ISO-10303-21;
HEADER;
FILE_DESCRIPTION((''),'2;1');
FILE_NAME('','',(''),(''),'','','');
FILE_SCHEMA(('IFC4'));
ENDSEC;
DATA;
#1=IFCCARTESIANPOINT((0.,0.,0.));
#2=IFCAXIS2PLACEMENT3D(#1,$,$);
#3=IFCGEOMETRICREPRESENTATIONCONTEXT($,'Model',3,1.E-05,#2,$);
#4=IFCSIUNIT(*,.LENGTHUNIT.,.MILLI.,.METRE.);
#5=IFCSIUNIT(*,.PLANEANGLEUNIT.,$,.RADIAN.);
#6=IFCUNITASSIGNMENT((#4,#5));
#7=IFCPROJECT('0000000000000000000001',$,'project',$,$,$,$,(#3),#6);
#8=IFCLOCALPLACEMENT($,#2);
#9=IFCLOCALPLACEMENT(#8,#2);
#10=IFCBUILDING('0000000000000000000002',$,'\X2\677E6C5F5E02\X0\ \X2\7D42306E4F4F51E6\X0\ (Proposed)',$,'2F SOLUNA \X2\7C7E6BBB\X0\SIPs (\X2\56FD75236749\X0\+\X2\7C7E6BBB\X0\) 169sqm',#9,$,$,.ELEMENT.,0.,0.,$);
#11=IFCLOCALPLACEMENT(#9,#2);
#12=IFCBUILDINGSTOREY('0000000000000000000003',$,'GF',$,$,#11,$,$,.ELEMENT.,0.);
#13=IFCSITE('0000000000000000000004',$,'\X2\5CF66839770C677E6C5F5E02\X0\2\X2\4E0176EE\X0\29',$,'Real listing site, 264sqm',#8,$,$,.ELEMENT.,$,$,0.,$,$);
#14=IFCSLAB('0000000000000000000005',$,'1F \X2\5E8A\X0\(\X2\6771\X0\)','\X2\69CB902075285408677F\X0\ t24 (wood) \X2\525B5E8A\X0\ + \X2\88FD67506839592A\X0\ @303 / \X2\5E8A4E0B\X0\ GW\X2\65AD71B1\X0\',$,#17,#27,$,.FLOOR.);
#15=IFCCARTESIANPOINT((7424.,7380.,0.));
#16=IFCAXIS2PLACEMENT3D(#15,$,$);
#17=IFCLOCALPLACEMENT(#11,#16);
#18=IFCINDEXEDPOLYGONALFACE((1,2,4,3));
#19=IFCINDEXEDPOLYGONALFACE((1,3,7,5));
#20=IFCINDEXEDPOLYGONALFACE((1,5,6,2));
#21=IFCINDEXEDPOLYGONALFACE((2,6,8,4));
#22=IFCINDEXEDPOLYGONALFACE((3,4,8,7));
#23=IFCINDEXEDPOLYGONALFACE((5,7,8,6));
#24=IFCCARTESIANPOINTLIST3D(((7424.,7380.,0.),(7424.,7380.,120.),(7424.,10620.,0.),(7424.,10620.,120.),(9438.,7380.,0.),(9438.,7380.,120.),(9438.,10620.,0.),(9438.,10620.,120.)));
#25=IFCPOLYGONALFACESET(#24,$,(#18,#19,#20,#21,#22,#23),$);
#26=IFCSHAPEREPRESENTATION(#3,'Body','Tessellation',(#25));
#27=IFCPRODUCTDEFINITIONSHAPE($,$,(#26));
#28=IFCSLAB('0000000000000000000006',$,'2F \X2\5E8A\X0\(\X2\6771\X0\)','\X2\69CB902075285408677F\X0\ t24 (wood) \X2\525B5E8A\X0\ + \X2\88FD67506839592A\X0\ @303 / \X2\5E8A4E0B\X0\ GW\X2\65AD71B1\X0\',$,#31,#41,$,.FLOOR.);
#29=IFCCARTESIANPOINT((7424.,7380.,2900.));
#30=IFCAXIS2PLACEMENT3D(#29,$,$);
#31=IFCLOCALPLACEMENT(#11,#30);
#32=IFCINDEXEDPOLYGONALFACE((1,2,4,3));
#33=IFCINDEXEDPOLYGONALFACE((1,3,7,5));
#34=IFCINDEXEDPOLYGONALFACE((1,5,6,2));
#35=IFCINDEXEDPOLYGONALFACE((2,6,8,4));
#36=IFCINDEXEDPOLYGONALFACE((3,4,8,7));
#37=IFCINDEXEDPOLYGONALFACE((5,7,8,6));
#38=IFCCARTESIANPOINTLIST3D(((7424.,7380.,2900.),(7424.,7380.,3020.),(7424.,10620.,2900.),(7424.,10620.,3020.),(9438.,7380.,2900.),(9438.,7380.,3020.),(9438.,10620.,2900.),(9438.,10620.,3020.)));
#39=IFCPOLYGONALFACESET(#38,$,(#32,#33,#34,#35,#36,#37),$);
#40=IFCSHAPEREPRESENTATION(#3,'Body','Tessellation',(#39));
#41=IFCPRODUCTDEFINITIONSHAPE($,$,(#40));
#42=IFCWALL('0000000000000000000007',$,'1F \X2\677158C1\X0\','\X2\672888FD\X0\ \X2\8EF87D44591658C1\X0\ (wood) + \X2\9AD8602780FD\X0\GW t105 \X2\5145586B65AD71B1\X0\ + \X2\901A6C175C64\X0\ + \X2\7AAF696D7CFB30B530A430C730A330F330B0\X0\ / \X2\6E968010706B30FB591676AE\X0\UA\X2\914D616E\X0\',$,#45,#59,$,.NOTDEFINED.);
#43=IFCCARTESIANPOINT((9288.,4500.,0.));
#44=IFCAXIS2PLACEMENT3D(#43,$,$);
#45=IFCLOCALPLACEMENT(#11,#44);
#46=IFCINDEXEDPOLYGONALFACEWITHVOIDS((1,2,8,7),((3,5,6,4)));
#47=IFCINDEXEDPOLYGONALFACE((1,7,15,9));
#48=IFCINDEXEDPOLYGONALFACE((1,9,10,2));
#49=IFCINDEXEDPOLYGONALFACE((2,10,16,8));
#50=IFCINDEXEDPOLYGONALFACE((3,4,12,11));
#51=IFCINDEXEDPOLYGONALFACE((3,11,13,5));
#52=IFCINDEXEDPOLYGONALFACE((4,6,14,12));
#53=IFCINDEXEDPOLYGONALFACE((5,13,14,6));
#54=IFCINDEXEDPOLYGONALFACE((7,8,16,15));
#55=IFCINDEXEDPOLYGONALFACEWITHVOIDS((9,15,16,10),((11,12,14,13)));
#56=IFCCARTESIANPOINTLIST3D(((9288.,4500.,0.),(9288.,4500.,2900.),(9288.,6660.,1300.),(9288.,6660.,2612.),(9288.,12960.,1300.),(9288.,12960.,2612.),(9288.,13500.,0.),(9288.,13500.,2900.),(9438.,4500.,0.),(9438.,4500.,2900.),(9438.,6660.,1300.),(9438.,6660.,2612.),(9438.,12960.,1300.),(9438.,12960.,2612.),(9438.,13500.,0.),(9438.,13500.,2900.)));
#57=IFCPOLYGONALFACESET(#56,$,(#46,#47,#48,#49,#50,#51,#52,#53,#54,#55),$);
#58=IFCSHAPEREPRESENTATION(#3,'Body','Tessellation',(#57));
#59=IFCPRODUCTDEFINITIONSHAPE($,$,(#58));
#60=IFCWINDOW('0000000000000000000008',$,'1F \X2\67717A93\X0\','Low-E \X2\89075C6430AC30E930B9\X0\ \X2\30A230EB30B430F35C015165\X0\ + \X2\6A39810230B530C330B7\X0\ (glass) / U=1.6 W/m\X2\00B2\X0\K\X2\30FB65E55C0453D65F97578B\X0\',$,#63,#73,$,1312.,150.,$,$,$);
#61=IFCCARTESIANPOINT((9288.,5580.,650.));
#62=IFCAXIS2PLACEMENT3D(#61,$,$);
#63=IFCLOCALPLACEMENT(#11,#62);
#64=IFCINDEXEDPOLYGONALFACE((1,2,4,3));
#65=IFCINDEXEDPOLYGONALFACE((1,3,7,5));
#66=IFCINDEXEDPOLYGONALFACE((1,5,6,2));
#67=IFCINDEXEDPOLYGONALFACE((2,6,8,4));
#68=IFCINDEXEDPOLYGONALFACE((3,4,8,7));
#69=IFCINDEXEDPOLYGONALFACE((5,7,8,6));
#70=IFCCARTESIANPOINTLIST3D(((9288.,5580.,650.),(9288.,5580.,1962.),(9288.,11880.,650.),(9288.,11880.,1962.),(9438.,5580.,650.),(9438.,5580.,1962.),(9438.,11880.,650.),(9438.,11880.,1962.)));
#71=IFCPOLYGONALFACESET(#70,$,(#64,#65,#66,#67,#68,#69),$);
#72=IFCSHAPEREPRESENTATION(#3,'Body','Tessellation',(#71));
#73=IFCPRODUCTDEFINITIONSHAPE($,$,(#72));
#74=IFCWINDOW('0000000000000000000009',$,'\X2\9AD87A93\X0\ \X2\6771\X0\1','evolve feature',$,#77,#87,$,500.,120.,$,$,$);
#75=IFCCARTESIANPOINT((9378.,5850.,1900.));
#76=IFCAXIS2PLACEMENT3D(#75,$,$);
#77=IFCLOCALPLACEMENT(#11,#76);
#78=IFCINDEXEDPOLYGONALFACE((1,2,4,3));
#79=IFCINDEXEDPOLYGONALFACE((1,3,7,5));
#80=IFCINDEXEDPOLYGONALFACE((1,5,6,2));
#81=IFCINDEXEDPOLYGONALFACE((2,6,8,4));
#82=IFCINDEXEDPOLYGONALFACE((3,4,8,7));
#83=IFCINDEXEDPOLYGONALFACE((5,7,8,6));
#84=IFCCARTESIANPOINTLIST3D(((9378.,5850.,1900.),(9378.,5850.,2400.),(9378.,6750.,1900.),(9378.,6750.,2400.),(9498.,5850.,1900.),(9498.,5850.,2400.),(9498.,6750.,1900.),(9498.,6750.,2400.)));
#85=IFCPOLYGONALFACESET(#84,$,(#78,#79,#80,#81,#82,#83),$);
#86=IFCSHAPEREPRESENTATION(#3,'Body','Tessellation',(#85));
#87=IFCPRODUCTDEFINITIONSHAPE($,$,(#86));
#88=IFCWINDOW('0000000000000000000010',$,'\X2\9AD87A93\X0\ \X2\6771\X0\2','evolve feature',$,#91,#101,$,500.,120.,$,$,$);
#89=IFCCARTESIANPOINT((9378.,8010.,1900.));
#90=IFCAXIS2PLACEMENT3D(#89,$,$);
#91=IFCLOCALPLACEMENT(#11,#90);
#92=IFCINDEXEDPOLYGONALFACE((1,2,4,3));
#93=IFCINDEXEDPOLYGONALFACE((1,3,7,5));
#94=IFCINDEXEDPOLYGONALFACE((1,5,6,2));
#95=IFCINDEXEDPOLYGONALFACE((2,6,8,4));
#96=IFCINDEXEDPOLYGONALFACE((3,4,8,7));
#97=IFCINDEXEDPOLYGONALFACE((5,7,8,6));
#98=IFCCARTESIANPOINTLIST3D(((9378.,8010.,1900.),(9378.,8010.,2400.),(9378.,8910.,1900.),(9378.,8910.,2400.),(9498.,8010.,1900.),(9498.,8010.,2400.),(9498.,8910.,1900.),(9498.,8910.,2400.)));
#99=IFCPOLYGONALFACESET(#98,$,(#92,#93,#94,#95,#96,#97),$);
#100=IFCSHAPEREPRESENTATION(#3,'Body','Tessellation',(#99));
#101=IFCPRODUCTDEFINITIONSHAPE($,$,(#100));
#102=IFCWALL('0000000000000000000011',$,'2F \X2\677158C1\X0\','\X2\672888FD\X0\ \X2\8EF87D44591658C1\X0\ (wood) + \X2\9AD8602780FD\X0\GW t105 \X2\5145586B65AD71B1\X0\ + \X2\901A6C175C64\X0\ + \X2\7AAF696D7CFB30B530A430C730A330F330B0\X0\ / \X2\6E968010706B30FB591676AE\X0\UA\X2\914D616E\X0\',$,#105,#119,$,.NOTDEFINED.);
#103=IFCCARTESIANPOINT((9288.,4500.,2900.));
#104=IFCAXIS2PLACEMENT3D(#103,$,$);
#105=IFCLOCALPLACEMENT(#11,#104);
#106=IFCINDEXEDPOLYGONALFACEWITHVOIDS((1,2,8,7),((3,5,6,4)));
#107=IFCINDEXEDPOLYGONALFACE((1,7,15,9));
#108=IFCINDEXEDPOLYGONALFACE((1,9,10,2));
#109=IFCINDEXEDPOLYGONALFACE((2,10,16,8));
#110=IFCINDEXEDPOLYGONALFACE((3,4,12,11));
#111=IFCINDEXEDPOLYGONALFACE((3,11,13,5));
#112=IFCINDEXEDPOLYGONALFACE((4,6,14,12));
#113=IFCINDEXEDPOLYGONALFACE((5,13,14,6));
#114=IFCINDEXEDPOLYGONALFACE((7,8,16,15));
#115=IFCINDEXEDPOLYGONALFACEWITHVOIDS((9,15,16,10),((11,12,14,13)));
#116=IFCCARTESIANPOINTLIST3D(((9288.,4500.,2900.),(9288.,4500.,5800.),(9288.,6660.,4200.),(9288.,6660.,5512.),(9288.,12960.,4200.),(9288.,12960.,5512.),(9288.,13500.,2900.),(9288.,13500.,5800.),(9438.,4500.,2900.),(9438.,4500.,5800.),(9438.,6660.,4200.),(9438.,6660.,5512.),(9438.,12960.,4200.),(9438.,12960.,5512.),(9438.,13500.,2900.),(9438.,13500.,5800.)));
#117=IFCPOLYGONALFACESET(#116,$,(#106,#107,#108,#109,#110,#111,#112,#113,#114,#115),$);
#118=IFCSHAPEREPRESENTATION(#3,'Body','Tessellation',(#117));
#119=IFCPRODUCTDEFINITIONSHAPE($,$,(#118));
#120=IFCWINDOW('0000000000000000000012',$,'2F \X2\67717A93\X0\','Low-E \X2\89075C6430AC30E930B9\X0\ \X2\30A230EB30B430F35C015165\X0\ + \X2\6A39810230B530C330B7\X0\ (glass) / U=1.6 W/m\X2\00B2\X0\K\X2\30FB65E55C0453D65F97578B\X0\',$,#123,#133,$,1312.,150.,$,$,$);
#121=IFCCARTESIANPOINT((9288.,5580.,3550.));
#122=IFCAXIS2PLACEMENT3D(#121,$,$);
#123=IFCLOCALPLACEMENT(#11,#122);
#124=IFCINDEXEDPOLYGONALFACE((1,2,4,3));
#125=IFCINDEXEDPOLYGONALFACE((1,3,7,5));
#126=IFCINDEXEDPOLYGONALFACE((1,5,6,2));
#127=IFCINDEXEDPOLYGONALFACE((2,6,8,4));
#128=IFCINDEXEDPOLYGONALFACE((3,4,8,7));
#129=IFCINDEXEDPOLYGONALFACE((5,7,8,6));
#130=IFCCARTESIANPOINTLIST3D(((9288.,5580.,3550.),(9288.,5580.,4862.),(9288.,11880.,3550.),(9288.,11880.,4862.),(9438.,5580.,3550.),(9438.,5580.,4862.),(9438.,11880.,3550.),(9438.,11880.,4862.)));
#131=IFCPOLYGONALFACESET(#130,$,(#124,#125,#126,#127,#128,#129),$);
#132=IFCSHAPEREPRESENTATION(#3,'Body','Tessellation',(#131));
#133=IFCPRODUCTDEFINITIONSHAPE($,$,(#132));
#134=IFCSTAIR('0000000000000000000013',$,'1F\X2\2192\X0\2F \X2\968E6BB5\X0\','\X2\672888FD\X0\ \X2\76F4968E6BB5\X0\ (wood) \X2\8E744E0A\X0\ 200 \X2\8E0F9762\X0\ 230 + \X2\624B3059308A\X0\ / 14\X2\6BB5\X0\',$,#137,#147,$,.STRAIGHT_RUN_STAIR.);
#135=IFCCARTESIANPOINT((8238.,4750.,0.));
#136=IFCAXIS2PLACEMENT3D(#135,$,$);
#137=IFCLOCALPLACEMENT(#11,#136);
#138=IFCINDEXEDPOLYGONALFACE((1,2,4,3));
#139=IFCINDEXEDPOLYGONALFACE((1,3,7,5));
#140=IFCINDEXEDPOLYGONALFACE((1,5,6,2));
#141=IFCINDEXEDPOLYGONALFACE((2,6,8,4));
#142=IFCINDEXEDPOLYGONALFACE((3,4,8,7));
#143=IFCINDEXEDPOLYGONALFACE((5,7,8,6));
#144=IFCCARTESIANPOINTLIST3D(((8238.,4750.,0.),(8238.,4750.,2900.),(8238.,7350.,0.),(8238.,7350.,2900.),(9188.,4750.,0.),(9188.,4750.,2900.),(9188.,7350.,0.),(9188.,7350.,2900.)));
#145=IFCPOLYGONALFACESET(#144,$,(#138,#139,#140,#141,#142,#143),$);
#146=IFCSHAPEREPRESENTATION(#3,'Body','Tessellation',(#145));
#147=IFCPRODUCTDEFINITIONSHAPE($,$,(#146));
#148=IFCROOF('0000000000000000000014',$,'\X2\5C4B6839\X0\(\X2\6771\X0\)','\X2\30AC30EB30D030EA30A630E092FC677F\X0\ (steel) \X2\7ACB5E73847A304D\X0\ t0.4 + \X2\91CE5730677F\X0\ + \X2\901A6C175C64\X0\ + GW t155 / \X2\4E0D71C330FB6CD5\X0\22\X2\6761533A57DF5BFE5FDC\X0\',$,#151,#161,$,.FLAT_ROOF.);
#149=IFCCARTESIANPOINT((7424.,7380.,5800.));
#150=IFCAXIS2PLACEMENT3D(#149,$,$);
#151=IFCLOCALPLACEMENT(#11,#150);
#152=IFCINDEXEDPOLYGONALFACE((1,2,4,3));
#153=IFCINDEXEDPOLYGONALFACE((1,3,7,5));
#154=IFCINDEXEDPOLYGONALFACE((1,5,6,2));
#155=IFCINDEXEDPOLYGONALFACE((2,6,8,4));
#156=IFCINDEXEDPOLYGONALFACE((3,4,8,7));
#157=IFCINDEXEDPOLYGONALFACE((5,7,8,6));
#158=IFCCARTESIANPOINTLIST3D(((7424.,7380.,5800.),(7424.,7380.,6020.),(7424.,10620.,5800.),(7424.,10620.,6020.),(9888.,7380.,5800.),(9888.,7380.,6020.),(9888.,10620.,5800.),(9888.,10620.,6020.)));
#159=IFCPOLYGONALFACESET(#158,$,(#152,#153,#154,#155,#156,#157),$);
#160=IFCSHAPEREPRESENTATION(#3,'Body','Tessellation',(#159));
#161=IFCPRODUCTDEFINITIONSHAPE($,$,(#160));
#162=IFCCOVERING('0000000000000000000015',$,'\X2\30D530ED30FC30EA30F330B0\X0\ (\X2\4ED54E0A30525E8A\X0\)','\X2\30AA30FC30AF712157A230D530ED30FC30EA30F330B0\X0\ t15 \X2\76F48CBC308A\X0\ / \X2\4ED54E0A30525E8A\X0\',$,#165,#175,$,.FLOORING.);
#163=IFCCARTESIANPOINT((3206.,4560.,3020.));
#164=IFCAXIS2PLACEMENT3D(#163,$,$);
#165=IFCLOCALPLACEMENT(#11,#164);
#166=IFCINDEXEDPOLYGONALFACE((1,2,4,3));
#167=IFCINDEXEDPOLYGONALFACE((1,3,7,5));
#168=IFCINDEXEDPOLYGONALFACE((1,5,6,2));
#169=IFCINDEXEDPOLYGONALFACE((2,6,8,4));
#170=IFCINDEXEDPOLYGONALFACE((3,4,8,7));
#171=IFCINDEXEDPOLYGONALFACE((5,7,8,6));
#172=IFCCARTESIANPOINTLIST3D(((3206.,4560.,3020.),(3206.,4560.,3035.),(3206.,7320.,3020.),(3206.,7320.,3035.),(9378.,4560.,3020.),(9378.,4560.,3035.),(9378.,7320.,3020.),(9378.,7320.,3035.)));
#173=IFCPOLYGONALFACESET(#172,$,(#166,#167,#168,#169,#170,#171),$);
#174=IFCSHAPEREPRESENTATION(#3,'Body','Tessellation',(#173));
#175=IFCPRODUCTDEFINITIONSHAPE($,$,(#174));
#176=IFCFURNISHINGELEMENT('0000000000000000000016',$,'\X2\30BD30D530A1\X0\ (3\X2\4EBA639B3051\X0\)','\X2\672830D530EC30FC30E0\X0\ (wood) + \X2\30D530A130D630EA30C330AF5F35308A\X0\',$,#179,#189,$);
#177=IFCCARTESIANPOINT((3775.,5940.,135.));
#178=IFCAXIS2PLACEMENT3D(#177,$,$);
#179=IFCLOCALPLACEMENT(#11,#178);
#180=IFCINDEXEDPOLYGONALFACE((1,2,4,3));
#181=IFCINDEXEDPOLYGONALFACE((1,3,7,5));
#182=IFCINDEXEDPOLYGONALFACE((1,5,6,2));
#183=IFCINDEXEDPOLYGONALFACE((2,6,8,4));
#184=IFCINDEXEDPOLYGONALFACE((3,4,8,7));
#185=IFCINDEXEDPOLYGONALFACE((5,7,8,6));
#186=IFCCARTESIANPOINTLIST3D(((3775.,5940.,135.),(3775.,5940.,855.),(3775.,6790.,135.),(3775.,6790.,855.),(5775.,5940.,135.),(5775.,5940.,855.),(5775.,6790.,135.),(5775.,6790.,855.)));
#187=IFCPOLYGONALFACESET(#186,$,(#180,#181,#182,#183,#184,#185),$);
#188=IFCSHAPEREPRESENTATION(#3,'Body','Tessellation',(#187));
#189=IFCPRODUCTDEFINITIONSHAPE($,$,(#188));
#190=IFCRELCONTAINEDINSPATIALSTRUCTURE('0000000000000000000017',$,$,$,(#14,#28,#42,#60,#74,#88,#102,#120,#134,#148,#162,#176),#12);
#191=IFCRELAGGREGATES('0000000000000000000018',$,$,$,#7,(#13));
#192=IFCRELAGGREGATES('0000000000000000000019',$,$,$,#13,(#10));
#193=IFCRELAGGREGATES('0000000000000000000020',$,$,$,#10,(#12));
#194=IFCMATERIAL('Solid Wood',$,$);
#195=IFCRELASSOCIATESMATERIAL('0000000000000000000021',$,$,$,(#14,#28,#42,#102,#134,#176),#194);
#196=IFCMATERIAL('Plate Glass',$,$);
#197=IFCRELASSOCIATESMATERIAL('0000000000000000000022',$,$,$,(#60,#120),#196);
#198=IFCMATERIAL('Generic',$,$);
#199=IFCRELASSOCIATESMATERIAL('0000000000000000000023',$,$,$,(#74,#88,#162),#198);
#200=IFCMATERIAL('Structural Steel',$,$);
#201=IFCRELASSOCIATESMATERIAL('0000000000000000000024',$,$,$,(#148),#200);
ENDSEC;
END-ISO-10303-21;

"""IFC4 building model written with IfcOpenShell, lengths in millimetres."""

from ifc_helpers import new_model, si_unit, frame, frame_2d, origin, place, context, project, spatial, rectangle, extrude, material, element, fill, save


model = new_model("IFC4")

# Units and contexts
model_context = context("Model", 3, precision=1e-05, world=origin())
ifc_project = project(units=[si_unit("LENGTHUNIT", "METRE", prefix="MILLI"), si_unit("PLANEANGLEUNIT", "RADIAN")], contexts=[model_context])

# Site, building, storey
site_placement = place(None, origin())
site = spatial("IfcSite", under=ifc_project, at=site_placement, Name="島根県松江市2丁目29", ObjectType="Real listing site, 264sqm", CompositionType="ELEMENT", RefElevation=0.0)
building_placement = place(site_placement, origin())
building = spatial("IfcBuilding", under=site, at=building_placement, Name="松江市 終の住処 (Proposed)", ObjectType="2F SOLUNA 籾殻SIPs (国産杉+籾殻) 169sqm", CompositionType="ELEMENT", ElevationOfRefHeight=0.0, ElevationOfTerrain=0.0)
storey_placement = place(building_placement, origin())
storey = spatial("IfcBuildingStorey", under=building, at=storey_placement, Name="GF", CompositionType="ELEMENT", Elevation=0.0)

# Slabs
ifc_material_1 = material(Name="Solid Wood")
slab_1_placement = place(storey_placement, frame((7424.0, 7380.0, 0.0)))
element("IfcSlab", 1, at=slab_1_placement, inside=storey, material=ifc_material_1, Name="1F 床(東)", Description="構造用合板 t24 (wood) 剛床 + 製材根太 @303 / 床下 GW断熱", PredefinedType="FLOOR", context=model_context, shape_type="SweptSolid", body=[
    extrude(rectangle(XDim=2014.0, YDim=3240.0, at=frame_2d((1007.0, 1620.0))), frame((7424.0, 7380.0, 0.0)), (0.0, 0.0, 1.0), 120.0),
])
slab_2_placement = place(storey_placement, frame((7424.0, 7380.0, 2900.0)))
element("IfcSlab", 2, at=slab_2_placement, inside=storey, material=ifc_material_1, Name="2F 床(東)", Description="構造用合板 t24 (wood) 剛床 + 製材根太 @303 / 床下 GW断熱", PredefinedType="FLOOR", context=model_context, shape_type="SweptSolid", body=[
    extrude(rectangle(XDim=2014.0, YDim=3240.0, at=frame_2d((1007.0, 1620.0))), frame((7424.0, 7380.0, 2900.0)), (0.0, 0.0, 1.0), 120.0),
])

# Wall, openings, windows
wall_1_placement = place(storey_placement, frame((9288.0, 4500.0, 0.0)))
wall_1 = element("IfcWall", 3, at=wall_1_placement, inside=storey, material=ifc_material_1, Name="1F 東壁", Description="木製 軸組外壁 (wood) + 高性能GW t105 充填断熱 + 通気層 + 窯業系サイディング / 準耐火・外皮UA配慮", PredefinedType="NOTDEFINED", context=model_context, shape_type="SweptSolid", body=[
    extrude(rectangle(XDim=150.0, YDim=9000.0, at=frame_2d((75.0, 4500.0))), frame((9288.0, 4500.0, 0.0)), (0.0, 0.0, 1.0), 2900.0),
])
opening_1_placement = place(storey_placement, frame((9288.0, 5580.0, 650.0)))
opening_1 = element("IfcOpeningElement", 4, at=opening_1_placement, cuts=wall_1, PredefinedType="NOTDEFINED", context=model_context, shape_type="SweptSolid", body=[
    extrude(rectangle(XDim=150.0, YDim=6300.0, at=frame_2d((75.0, 3150.0))), frame((9288.0, 5580.0, 650.0)), (0.0, 0.0, 1.0), 1312.0),
])
opening_2_placement = place(storey_placement, frame((9378.0, 5850.0, 1900.0)))
opening_2 = element("IfcOpeningElement", 5, at=opening_2_placement, cuts=wall_1, PredefinedType="NOTDEFINED", context=model_context, shape_type="SweptSolid", body=[
    extrude(rectangle(XDim=120.0, YDim=900.0, at=frame_2d((60.0, 450.0))), frame((9378.0, 5850.0, 1900.0)), (0.0, 0.0, 1.0), 500.0),
])
opening_3_placement = place(storey_placement, frame((9378.0, 8010.0, 1900.0)))
opening_3 = element("IfcOpeningElement", 6, at=opening_3_placement, cuts=wall_1, PredefinedType="NOTDEFINED", context=model_context, shape_type="SweptSolid", body=[
    extrude(rectangle(XDim=120.0, YDim=900.0, at=frame_2d((60.0, 450.0))), frame((9378.0, 8010.0, 1900.0)), (0.0, 0.0, 1.0), 500.0),
])
ifc_material_2 = material(Name="Plate Glass")
window_1_placement = place(storey_placement, frame((9288.0, 5580.0, 650.0)))
window_1 = element("IfcWindow", 7, at=window_1_placement, inside=storey, material=ifc_material_2, Name="1F 東窓", Description="Low-E 複層ガラス アルゴン封入 + 樹脂サッシ (glass) / U=1.6 W/m²K・日射取得型", OverallHeight=1312.0, OverallWidth=150.0, context=model_context, shape_type="SweptSolid", body=[
    extrude(rectangle(XDim=150.0, YDim=6300.0, at=frame_2d((75.0, 3150.0))), frame((9288.0, 5580.0, 650.0)), (0.0, 0.0, 1.0), 1312.0),
])
fill(opening_1, window_1)
ifc_material_3 = material(Name="Generic")
window_2_placement = place(storey_placement, frame((9378.0, 5850.0, 1900.0)))
window_2 = element("IfcWindow", 8, at=window_2_placement, inside=storey, material=ifc_material_3, Name="高窓 東1", Description="evolve feature", OverallHeight=500.0, OverallWidth=120.0, context=model_context, shape_type="SweptSolid", body=[
    extrude(rectangle(XDim=120.0, YDim=900.0, at=frame_2d((60.0, 450.0))), frame((9378.0, 5850.0, 1900.0)), (0.0, 0.0, 1.0), 500.0),
])
fill(opening_2, window_2)
window_3_placement = place(storey_placement, frame((9378.0, 8010.0, 1900.0)))
window_3 = element("IfcWindow", 9, at=window_3_placement, inside=storey, material=ifc_material_3, Name="高窓 東2", Description="evolve feature", OverallHeight=500.0, OverallWidth=120.0, context=model_context, shape_type="SweptSolid", body=[
    extrude(rectangle(XDim=120.0, YDim=900.0, at=frame_2d((60.0, 450.0))), frame((9378.0, 8010.0, 1900.0)), (0.0, 0.0, 1.0), 500.0),
])
fill(opening_3, window_3)

# Wall, opening, window
wall_2_placement = place(storey_placement, frame((9288.0, 4500.0, 2900.0)))
wall_2 = element("IfcWall", 10, at=wall_2_placement, inside=storey, material=ifc_material_1, Name="2F 東壁", Description="木製 軸組外壁 (wood) + 高性能GW t105 充填断熱 + 通気層 + 窯業系サイディング / 準耐火・外皮UA配慮", PredefinedType="NOTDEFINED", context=model_context, shape_type="SweptSolid", body=[
    extrude(rectangle(XDim=150.0, YDim=9000.0, at=frame_2d((75.0, 4500.0))), frame((9288.0, 4500.0, 2900.0)), (0.0, 0.0, 1.0), 2900.0),
])
opening_4_placement = place(storey_placement, frame((9288.0, 5580.0, 3550.0)))
opening_4 = element("IfcOpeningElement", 11, at=opening_4_placement, cuts=wall_2, PredefinedType="NOTDEFINED", context=model_context, shape_type="SweptSolid", body=[
    extrude(rectangle(XDim=150.0, YDim=6300.0, at=frame_2d((75.0, 3150.0))), frame((9288.0, 5580.0, 3550.0)), (0.0, 0.0, 1.0), 1312.0),
])
window_4_placement = place(storey_placement, frame((9288.0, 5580.0, 3550.0)))
window_4 = element("IfcWindow", 12, at=window_4_placement, inside=storey, material=ifc_material_2, Name="2F 東窓", Description="Low-E 複層ガラス アルゴン封入 + 樹脂サッシ (glass) / U=1.6 W/m²K・日射取得型", OverallHeight=1312.0, OverallWidth=150.0, context=model_context, shape_type="SweptSolid", body=[
    extrude(rectangle(XDim=150.0, YDim=6300.0, at=frame_2d((75.0, 3150.0))), frame((9288.0, 5580.0, 3550.0)), (0.0, 0.0, 1.0), 1312.0),
])
fill(opening_4, window_4)

# Stair
stair_placement = place(storey_placement, frame((8238.0, 4750.0, 0.0)))
element("IfcStair", 13, at=stair_placement, inside=storey, material=ifc_material_1, Name="1F→2F 階段", Description="木製 直階段 (wood) 蹴上 200 踏面 230 + 手すり / 14段", PredefinedType="STRAIGHT_RUN_STAIR", context=model_context, shape_type="SweptSolid", body=[
    extrude(rectangle(XDim=950.0, YDim=2600.0, at=frame_2d((475.0, 1300.0))), frame((8238.0, 4750.0, 0.0)), (0.0, 0.0, 1.0), 2900.0),
])

# Roof
ifc_material_4 = material(Name="Structural Steel")
roof_placement = place(storey_placement, frame((7424.0, 7380.0, 5800.0)))
element("IfcRoof", 14, at=roof_placement, inside=storey, material=ifc_material_4, Name="屋根(東)", Description="ガルバリウム鋼板 (steel) 立平葺き t0.4 + 野地板 + 通気層 + GW t155 / 不燃・法22条区域対応", PredefinedType="FLAT_ROOF", context=model_context, shape_type="SweptSolid", body=[
    extrude(rectangle(XDim=2464.0, YDim=3240.0, at=frame_2d((1232.0, 1620.0))), frame((7424.0, 7380.0, 5800.0)), (0.0, 0.0, 1.0), 220.0),
])

# Covering
covering_placement = place(storey_placement, frame((3206.0, 4560.0, 3020.0)))
element("IfcCovering", 15, at=covering_placement, inside=storey, material=ifc_material_3, Name="フローリング (仕上げ床)", Description="オーク無垢フローリング t15 直貼り / 仕上げ床", PredefinedType="FLOORING", context=model_context, shape_type="SweptSolid", body=[
    extrude(rectangle(XDim=6172.0, YDim=2760.0, at=frame_2d((3086.0, 1380.0))), frame((3206.0, 4560.0, 3020.0)), (0.0, 0.0, 1.0), 15.0),
])

# Furnishing element
furnishing_1_placement = place(storey_placement, frame((3775.0, 5940.0, 135.0)))
element("IfcFurnishingElement", 16, at=furnishing_1_placement, inside=storey, material=ifc_material_1, Name="ソファ (3人掛け)", Description="木フレーム (wood) + ファブリック張り", context=model_context, shape_type="SweptSolid", body=[
    extrude(rectangle(XDim=2000.0, YDim=850.0, at=frame_2d((1000.0, 425.0))), frame((3775.0, 5940.0, 135.0)), (0.0, 0.0, 1.0), 720.0),
])

save(model, "model.ifc")
